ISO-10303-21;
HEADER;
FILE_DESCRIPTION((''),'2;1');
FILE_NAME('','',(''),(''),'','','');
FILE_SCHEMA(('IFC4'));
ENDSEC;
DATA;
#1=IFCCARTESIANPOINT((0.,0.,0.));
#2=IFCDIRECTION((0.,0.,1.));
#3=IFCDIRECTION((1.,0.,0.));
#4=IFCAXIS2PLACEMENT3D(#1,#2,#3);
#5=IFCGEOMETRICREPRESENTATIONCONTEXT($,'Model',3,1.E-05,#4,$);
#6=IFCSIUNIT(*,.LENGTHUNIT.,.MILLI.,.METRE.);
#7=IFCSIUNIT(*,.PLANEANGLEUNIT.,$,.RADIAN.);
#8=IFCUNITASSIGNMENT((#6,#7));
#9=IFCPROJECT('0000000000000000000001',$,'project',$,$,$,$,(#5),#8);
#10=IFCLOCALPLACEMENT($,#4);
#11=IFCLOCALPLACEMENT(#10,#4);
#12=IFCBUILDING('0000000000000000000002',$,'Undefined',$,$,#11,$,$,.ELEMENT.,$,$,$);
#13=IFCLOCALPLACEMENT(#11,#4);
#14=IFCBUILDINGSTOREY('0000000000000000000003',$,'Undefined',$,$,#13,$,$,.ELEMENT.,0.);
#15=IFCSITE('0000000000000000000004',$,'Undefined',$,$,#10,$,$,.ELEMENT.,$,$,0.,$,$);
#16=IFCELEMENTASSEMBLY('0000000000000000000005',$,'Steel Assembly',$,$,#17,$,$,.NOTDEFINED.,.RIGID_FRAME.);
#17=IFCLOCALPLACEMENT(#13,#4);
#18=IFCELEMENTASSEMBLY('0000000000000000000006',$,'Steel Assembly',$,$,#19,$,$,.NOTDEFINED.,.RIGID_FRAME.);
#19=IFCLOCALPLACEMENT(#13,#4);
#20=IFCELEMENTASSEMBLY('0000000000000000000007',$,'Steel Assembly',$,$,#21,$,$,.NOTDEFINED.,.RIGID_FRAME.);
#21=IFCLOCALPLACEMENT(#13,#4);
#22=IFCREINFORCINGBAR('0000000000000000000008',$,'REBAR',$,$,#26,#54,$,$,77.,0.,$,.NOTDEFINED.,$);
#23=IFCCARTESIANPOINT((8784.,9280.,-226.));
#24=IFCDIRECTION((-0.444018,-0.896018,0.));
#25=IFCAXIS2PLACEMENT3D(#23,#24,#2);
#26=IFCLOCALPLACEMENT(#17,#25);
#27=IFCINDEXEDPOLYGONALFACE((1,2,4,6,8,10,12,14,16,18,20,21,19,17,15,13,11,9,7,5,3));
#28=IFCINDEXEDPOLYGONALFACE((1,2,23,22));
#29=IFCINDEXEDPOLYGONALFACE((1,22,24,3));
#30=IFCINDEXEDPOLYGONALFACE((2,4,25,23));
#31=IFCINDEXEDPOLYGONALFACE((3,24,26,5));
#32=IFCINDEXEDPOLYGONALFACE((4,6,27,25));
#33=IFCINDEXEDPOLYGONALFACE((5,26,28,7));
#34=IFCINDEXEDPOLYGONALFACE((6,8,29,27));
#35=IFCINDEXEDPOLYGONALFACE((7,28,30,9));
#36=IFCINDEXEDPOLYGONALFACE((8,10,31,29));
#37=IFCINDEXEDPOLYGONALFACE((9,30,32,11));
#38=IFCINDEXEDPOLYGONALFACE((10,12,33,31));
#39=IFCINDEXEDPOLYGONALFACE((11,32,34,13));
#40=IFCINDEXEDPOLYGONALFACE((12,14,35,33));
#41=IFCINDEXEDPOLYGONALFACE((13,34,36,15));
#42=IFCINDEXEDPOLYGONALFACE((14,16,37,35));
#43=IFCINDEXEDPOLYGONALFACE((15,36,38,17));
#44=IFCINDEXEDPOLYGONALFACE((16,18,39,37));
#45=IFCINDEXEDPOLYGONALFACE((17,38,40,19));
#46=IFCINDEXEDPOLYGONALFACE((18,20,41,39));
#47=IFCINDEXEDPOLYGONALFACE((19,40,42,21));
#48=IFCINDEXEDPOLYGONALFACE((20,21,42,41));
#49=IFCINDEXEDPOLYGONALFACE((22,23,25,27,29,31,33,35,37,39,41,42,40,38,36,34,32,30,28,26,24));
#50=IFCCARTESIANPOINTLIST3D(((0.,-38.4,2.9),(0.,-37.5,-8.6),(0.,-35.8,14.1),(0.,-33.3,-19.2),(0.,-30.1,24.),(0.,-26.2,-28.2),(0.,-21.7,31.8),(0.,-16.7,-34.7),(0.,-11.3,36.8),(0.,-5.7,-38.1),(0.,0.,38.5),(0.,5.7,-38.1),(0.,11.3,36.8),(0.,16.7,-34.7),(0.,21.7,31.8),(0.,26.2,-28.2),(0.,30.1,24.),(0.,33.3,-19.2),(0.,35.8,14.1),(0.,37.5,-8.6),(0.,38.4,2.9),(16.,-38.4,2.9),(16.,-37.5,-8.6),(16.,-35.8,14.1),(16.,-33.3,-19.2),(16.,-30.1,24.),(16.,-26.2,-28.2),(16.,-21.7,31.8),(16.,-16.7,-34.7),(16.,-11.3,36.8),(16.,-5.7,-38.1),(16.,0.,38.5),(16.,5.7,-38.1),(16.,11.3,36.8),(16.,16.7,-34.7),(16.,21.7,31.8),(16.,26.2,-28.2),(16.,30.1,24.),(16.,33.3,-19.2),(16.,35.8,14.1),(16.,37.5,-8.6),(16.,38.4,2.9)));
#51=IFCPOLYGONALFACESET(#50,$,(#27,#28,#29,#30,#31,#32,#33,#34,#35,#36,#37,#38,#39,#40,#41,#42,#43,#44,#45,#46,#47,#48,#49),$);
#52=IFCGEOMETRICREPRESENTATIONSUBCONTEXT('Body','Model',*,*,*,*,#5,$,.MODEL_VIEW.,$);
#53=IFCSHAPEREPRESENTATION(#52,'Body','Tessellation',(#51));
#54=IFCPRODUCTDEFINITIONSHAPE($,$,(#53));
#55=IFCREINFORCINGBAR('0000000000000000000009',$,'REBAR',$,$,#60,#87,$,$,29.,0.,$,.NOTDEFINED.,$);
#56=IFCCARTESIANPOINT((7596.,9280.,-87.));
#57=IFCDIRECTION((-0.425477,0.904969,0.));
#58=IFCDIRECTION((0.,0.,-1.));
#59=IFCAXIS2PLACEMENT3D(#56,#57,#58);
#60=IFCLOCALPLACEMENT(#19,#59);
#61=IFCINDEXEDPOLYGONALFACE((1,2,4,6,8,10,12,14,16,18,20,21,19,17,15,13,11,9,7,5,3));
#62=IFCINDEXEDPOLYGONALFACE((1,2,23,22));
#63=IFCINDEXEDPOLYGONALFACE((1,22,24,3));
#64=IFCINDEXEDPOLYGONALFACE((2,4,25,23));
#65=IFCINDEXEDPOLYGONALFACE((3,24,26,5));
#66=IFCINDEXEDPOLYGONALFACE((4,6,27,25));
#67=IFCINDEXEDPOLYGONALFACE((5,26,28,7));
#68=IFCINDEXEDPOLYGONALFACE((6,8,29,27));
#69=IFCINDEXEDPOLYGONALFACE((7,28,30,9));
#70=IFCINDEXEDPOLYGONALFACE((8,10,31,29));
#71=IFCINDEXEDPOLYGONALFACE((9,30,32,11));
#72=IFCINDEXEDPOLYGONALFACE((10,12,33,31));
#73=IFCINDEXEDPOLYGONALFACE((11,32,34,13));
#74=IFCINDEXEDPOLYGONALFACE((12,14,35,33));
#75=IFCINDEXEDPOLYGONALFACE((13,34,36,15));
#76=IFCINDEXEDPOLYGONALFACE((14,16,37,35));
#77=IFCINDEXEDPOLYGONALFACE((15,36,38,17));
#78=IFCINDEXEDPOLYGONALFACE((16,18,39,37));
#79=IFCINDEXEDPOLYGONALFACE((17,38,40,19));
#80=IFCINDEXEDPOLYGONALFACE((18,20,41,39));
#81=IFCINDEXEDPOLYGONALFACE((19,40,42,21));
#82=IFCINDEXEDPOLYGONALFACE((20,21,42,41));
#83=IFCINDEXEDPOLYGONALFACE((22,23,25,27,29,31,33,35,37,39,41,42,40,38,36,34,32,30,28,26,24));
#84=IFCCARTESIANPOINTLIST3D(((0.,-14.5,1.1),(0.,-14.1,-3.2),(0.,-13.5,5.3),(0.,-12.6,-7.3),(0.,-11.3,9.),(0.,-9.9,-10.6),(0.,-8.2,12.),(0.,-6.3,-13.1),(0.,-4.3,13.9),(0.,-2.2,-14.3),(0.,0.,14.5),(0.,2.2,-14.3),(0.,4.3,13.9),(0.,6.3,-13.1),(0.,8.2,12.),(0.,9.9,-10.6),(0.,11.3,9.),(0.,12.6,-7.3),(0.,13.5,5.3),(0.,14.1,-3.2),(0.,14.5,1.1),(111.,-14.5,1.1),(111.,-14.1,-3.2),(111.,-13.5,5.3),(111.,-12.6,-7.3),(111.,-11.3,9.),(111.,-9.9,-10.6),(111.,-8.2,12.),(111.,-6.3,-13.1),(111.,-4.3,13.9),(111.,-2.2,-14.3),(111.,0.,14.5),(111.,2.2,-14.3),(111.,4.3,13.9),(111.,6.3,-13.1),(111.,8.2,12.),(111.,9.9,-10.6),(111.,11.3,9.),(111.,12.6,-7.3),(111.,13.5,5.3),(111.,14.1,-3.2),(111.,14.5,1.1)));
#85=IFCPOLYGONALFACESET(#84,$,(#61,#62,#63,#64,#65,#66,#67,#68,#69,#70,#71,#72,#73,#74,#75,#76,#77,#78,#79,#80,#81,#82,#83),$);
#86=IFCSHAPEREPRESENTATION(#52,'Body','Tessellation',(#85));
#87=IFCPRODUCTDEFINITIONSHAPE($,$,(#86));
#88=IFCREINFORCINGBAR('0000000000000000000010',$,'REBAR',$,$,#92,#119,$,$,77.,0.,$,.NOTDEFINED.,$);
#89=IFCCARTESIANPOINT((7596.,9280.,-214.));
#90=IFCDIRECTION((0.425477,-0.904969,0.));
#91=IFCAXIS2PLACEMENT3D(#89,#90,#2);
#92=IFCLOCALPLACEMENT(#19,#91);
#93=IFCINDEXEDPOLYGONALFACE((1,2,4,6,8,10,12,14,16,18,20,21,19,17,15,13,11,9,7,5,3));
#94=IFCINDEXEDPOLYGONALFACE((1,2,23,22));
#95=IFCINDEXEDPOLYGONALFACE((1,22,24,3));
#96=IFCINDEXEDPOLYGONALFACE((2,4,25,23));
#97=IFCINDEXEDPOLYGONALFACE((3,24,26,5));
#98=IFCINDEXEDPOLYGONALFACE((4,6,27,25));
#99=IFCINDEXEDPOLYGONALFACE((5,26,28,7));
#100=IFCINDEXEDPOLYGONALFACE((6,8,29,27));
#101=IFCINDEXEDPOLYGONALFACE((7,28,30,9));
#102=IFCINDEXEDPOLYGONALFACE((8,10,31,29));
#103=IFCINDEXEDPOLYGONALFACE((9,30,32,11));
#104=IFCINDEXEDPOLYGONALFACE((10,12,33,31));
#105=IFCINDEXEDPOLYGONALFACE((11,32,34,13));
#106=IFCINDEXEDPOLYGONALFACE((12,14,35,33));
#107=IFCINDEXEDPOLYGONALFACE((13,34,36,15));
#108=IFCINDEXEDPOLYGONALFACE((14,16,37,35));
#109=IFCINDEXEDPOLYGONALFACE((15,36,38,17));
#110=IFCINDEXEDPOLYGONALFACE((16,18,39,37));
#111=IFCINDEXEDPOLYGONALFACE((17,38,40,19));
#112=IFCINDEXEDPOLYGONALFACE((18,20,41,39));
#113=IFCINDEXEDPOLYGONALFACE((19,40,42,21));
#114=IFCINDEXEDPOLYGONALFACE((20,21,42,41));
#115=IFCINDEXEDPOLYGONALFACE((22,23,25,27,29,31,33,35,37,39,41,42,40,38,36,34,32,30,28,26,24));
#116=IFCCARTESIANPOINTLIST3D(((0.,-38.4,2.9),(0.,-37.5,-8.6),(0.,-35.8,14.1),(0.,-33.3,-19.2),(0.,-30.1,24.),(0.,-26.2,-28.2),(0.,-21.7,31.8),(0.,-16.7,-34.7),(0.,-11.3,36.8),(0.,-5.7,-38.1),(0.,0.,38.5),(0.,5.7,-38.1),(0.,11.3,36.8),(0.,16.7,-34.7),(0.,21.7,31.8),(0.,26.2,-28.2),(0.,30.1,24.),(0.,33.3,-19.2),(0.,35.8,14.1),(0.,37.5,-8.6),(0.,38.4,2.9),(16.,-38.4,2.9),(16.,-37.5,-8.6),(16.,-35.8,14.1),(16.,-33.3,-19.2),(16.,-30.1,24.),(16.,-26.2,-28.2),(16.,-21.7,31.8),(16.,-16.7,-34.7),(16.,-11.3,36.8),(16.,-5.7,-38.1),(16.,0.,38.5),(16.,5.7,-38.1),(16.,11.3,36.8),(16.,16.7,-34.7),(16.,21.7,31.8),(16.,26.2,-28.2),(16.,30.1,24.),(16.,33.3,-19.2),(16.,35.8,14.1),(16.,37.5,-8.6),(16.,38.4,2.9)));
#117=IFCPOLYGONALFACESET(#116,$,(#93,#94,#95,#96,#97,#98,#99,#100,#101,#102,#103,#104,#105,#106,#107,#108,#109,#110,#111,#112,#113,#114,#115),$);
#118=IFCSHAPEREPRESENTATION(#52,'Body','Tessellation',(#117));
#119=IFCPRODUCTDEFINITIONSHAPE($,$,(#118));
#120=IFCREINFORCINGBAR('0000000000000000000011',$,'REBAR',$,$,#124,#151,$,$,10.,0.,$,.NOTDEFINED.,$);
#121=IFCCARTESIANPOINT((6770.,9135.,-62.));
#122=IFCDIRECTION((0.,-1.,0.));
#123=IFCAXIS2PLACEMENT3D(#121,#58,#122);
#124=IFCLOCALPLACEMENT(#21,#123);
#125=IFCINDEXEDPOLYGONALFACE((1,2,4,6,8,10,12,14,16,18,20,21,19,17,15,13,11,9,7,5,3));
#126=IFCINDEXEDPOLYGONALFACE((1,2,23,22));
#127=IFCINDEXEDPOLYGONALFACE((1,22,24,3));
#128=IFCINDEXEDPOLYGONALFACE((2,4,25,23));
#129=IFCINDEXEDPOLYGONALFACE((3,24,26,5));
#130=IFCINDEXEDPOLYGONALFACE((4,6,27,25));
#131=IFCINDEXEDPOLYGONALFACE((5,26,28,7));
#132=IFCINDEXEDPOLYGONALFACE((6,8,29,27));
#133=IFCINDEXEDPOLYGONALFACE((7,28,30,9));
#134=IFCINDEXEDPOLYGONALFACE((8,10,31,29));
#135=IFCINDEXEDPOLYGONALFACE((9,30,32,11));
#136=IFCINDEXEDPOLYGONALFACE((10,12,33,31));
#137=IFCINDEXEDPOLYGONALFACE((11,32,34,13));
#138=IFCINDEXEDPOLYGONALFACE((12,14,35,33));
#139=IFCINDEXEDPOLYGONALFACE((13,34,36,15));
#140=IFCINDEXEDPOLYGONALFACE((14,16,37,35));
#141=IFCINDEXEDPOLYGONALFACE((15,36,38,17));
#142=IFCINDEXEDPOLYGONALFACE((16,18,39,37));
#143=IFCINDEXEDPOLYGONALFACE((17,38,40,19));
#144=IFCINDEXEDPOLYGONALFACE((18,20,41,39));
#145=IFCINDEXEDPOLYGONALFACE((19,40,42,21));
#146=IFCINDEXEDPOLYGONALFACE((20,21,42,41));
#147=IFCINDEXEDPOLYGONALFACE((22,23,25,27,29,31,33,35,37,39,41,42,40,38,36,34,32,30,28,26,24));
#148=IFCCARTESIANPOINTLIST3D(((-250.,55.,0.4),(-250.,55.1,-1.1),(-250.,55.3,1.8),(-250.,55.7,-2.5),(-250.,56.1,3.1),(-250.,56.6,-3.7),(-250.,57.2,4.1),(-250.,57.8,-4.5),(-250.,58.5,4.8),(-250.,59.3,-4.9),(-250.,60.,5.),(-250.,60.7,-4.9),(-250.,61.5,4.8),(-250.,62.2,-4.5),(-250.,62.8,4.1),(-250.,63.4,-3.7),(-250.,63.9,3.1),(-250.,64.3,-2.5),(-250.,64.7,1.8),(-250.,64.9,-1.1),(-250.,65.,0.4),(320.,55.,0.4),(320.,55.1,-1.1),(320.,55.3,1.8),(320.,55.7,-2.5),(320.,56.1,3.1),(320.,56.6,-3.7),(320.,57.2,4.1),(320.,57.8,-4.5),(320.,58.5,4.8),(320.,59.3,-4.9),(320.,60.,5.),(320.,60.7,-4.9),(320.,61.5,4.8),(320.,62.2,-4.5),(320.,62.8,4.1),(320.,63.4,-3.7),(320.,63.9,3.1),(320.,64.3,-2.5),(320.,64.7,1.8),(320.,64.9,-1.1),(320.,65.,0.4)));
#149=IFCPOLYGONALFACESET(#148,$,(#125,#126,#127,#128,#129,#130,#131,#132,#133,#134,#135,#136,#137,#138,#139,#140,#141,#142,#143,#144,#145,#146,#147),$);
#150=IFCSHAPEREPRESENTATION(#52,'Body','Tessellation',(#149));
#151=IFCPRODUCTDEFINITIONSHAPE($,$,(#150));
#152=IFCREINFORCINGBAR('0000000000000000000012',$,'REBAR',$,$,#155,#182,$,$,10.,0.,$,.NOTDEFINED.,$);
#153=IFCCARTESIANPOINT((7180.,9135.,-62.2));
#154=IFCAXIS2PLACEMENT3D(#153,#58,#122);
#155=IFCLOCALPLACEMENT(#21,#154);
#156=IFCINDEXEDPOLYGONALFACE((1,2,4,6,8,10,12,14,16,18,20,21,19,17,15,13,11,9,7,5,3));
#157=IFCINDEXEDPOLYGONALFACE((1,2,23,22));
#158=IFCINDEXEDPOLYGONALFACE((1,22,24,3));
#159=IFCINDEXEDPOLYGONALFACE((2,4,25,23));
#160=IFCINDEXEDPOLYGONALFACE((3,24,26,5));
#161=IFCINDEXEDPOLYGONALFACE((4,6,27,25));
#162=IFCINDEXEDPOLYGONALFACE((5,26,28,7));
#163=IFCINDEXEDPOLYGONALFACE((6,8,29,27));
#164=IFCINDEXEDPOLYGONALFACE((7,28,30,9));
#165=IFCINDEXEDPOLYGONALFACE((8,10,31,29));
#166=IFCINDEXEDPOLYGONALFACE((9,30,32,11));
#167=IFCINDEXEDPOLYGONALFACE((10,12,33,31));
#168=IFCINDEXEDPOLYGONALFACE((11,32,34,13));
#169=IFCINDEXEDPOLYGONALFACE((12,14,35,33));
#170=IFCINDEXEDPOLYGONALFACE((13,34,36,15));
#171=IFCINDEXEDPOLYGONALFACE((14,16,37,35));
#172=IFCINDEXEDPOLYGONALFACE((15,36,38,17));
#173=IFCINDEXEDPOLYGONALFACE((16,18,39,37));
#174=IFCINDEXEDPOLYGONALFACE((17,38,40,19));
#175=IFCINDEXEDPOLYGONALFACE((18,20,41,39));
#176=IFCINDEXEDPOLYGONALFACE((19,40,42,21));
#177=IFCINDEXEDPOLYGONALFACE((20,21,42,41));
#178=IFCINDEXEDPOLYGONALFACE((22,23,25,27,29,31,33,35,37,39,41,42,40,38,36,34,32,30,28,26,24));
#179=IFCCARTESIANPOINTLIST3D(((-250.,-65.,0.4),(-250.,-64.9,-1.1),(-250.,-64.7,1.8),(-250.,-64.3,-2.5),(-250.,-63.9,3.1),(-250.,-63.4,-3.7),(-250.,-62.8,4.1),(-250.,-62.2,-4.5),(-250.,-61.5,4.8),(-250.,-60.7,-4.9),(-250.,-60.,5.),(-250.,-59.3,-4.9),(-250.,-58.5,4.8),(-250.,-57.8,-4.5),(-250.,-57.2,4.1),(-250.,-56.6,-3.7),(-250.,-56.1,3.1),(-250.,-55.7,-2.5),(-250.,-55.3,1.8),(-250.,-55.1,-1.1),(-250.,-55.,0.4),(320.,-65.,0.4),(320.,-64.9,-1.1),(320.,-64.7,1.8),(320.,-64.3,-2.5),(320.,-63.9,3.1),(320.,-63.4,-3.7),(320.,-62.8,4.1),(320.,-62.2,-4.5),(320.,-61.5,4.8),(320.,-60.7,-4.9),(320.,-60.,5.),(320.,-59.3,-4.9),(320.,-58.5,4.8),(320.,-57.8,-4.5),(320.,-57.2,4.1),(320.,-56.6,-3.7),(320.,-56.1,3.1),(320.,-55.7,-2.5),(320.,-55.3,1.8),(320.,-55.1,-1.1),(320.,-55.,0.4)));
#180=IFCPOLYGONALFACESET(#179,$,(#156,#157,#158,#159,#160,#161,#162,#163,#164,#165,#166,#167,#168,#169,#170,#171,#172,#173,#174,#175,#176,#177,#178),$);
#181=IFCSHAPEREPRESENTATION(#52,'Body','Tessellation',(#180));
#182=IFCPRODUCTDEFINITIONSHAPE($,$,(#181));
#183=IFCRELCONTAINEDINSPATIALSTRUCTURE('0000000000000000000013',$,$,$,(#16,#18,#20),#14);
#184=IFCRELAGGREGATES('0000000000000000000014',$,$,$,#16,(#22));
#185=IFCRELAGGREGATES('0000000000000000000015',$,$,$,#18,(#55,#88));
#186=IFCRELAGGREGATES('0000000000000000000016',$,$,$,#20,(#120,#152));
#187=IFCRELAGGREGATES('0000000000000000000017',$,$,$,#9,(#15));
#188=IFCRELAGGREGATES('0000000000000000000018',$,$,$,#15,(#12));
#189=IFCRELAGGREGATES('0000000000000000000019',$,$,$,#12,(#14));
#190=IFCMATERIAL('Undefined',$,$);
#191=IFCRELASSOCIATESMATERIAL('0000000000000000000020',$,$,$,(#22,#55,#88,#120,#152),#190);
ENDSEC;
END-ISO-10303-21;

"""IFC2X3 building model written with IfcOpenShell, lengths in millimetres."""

from ifc_helpers import new_model, entity, si_unit, frame, origin_with_axes, place, context, subcontext, project, spatial, source, transform, mapped, material, element, aggregate, save


model = new_model("IFC2X3")

# Units and contexts
model_context = context("Model", 3, precision=1e-05, world=origin_with_axes())
body_context = subcontext(model_context, "Body", "Model", "MODEL_VIEW")
ifc_project = project(units=[si_unit("LENGTHUNIT", "METRE", prefix="MILLI"), si_unit("PLANEANGLEUNIT", "RADIAN")], contexts=[model_context])

# Site, building, storey
site_placement = place(None, origin_with_axes())
site = spatial("IfcSite", under=ifc_project, at=site_placement, Name="Undefined", CompositionType="ELEMENT", RefElevation=0.0)
building_placement = place(site_placement, origin_with_axes())
building = spatial("IfcBuilding", under=site, at=building_placement, Name="Undefined", CompositionType="ELEMENT")
storey_placement = place(building_placement, origin_with_axes())
storey = spatial("IfcBuildingStorey", under=building, at=storey_placement, Name="Undefined", CompositionType="ELEMENT", Elevation=0.0)

# Element assemblies
assembly_1_placement = place(storey_placement, origin_with_axes())
assembly_1 = element("IfcElementAssembly", 1, at=assembly_1_placement, inside=storey, Name="Steel Assembly", AssemblyPlace="NOTDEFINED", PredefinedType="RIGID_FRAME")
assembly_2_placement = place(storey_placement, origin_with_axes())
assembly_2 = element("IfcElementAssembly", 2, at=assembly_2_placement, inside=storey, Name="Steel Assembly", AssemblyPlace="NOTDEFINED", PredefinedType="RIGID_FRAME")

# Element assembly
assembly_3_placement = place(storey_placement, origin_with_axes())
assembly_3 = element("IfcElementAssembly", 3, at=assembly_3_placement, inside=storey, Name="Steel Assembly", AssemblyPlace="NOTDEFINED", PredefinedType="RIGID_FRAME")

# Reinforcing bars
ifc_material_1 = material(Name="Undefined")
shared_shape_1 = source(origin_with_axes(), body_context, "Body", "AdvancedSweptSolid", [
    entity("IfcSweptDiskSolid", entity("IfcTrimmedCurve", entity("IfcLine", entity("IfcCartesianPoint", [0.0, 0.0, 0.0]), entity("IfcVector", entity("IfcDirection", [1.0, 0.0, 0.0]), 1.0)), [entity("IfcParameterValue", 0.0)], [entity("IfcParameterValue", 16.0)], True, "PARAMETER"), 38.5, None, 0.0, 16.0),
])
reinforcing_bar_1_placement = place(assembly_1_placement, frame((8784.0, 9280.0, -226.0), z_axis=(-0.444018, -0.896018, 0.0), x_axis=(0.0, 0.0, 1.0)))
reinforcing_bar_1 = element("IfcReinforcingBar", 4, at=reinforcing_bar_1_placement, material=ifc_material_1, Name="REBAR", BarRole="NOTDEFINED", CrossSectionArea=0.0, NominalDiameter=77.0, context=body_context, shape_type="MappedRepresentation", body=[
    mapped(shared_shape_1, transform((0.0, 0.0, 0.0))),
])
aggregate(assembly_1, [reinforcing_bar_1])
shared_shape_2 = source(origin_with_axes(), body_context, "Body", "AdvancedSweptSolid", [
    entity("IfcSweptDiskSolid", entity("IfcTrimmedCurve", entity("IfcLine", entity("IfcCartesianPoint", [0.0, 0.0, 0.0]), entity("IfcVector", entity("IfcDirection", [1.0, 0.0, 0.0]), 1.0)), [entity("IfcParameterValue", 0.0)], [entity("IfcParameterValue", 111.0)], True, "PARAMETER"), 14.5, None, 0.0, 111.0),
])
reinforcing_bar_2_placement = place(assembly_2_placement, frame((7596.0, 9280.0, -87.0), z_axis=(-0.425477, 0.904969, 0.0), x_axis=(0.0, 0.0, -1.0)))
reinforcing_bar_2 = element("IfcReinforcingBar", 5, at=reinforcing_bar_2_placement, material=ifc_material_1, Name="REBAR", BarRole="NOTDEFINED", CrossSectionArea=0.0, NominalDiameter=29.0, context=body_context, shape_type="MappedRepresentation", body=[
    mapped(shared_shape_2, transform((0.0, 0.0, 0.0))),
])
shared_shape_3 = source(origin_with_axes(), body_context, "Body", "AdvancedSweptSolid", [
    entity("IfcSweptDiskSolid", entity("IfcTrimmedCurve", entity("IfcLine", entity("IfcCartesianPoint", [0.0, 0.0, 0.0]), entity("IfcVector", entity("IfcDirection", [1.0, 0.0, 0.0]), 1.0)), [entity("IfcParameterValue", 0.0)], [entity("IfcParameterValue", 16.0)], True, "PARAMETER"), 38.5, None, 0.0, 16.0),
])
reinforcing_bar_3_placement = place(assembly_2_placement, frame((7596.0, 9280.0, -214.0), z_axis=(0.425477, -0.904969, 0.0), x_axis=(0.0, 0.0, 1.0)))
reinforcing_bar_3 = element("IfcReinforcingBar", 6, at=reinforcing_bar_3_placement, material=ifc_material_1, Name="REBAR", BarRole="NOTDEFINED", CrossSectionArea=0.0, NominalDiameter=77.0, context=body_context, shape_type="MappedRepresentation", body=[
    mapped(shared_shape_3, transform((0.0, 0.0, 0.0))),
])
aggregate(assembly_2, [reinforcing_bar_2, reinforcing_bar_3])

# Reinforcing bars
shared_shape_4 = source(origin_with_axes(), body_context, "Body", "AdvancedSweptSolid", [
    entity("IfcSweptDiskSolid", entity("IfcTrimmedCurve", entity("IfcLine", entity("IfcCartesianPoint", [0.0, 0.0, 0.0]), entity("IfcVector", entity("IfcDirection", [1.0, 0.0, 0.0]), 1.0)), [entity("IfcParameterValue", 0.0)], [entity("IfcParameterValue", 570.0)], True, "PARAMETER"), 5.0, None, 0.0, 570.0),
])
reinforcing_bar_4_placement = place(assembly_3_placement, frame((6770.0, 9135.0, -62.0), z_axis=(0.0, 0.0, -1.0), x_axis=(0.0, -1.0, 0.0)))
reinforcing_bar_4 = element("IfcReinforcingBar", 7, at=reinforcing_bar_4_placement, material=ifc_material_1, Name="REBAR", BarRole="NOTDEFINED", CrossSectionArea=0.0, NominalDiameter=10.0, context=body_context, shape_type="MappedRepresentation", body=[
    mapped(shared_shape_4, transform((-250.0, 60.0, 0.0))),
])
shared_shape_5 = source(origin_with_axes(), body_context, "Body", "AdvancedSweptSolid", [
    entity("IfcSweptDiskSolid", entity("IfcTrimmedCurve", entity("IfcLine", entity("IfcCartesianPoint", [0.0, 0.0, 0.0]), entity("IfcVector", entity("IfcDirection", [1.0, 0.0, 0.0]), 1.0)), [entity("IfcParameterValue", 0.0)], [entity("IfcParameterValue", 570.0)], True, "PARAMETER"), 5.0, None, 0.0, 570.0),
])
reinforcing_bar_5_placement = place(assembly_3_placement, frame((7180.0, 9135.0, -62.2), z_axis=(0.0, 0.0, -1.0), x_axis=(0.0, -1.0, 0.0)))
reinforcing_bar_5 = element("IfcReinforcingBar", 8, at=reinforcing_bar_5_placement, material=ifc_material_1, Name="REBAR", BarRole="NOTDEFINED", CrossSectionArea=0.0, NominalDiameter=10.0, context=body_context, shape_type="MappedRepresentation", body=[
    mapped(shared_shape_5, transform((-250.0, -60.0, 0.0))),
])
aggregate(assembly_3, [reinforcing_bar_4, reinforcing_bar_5])

save(model, "model.ifc")
